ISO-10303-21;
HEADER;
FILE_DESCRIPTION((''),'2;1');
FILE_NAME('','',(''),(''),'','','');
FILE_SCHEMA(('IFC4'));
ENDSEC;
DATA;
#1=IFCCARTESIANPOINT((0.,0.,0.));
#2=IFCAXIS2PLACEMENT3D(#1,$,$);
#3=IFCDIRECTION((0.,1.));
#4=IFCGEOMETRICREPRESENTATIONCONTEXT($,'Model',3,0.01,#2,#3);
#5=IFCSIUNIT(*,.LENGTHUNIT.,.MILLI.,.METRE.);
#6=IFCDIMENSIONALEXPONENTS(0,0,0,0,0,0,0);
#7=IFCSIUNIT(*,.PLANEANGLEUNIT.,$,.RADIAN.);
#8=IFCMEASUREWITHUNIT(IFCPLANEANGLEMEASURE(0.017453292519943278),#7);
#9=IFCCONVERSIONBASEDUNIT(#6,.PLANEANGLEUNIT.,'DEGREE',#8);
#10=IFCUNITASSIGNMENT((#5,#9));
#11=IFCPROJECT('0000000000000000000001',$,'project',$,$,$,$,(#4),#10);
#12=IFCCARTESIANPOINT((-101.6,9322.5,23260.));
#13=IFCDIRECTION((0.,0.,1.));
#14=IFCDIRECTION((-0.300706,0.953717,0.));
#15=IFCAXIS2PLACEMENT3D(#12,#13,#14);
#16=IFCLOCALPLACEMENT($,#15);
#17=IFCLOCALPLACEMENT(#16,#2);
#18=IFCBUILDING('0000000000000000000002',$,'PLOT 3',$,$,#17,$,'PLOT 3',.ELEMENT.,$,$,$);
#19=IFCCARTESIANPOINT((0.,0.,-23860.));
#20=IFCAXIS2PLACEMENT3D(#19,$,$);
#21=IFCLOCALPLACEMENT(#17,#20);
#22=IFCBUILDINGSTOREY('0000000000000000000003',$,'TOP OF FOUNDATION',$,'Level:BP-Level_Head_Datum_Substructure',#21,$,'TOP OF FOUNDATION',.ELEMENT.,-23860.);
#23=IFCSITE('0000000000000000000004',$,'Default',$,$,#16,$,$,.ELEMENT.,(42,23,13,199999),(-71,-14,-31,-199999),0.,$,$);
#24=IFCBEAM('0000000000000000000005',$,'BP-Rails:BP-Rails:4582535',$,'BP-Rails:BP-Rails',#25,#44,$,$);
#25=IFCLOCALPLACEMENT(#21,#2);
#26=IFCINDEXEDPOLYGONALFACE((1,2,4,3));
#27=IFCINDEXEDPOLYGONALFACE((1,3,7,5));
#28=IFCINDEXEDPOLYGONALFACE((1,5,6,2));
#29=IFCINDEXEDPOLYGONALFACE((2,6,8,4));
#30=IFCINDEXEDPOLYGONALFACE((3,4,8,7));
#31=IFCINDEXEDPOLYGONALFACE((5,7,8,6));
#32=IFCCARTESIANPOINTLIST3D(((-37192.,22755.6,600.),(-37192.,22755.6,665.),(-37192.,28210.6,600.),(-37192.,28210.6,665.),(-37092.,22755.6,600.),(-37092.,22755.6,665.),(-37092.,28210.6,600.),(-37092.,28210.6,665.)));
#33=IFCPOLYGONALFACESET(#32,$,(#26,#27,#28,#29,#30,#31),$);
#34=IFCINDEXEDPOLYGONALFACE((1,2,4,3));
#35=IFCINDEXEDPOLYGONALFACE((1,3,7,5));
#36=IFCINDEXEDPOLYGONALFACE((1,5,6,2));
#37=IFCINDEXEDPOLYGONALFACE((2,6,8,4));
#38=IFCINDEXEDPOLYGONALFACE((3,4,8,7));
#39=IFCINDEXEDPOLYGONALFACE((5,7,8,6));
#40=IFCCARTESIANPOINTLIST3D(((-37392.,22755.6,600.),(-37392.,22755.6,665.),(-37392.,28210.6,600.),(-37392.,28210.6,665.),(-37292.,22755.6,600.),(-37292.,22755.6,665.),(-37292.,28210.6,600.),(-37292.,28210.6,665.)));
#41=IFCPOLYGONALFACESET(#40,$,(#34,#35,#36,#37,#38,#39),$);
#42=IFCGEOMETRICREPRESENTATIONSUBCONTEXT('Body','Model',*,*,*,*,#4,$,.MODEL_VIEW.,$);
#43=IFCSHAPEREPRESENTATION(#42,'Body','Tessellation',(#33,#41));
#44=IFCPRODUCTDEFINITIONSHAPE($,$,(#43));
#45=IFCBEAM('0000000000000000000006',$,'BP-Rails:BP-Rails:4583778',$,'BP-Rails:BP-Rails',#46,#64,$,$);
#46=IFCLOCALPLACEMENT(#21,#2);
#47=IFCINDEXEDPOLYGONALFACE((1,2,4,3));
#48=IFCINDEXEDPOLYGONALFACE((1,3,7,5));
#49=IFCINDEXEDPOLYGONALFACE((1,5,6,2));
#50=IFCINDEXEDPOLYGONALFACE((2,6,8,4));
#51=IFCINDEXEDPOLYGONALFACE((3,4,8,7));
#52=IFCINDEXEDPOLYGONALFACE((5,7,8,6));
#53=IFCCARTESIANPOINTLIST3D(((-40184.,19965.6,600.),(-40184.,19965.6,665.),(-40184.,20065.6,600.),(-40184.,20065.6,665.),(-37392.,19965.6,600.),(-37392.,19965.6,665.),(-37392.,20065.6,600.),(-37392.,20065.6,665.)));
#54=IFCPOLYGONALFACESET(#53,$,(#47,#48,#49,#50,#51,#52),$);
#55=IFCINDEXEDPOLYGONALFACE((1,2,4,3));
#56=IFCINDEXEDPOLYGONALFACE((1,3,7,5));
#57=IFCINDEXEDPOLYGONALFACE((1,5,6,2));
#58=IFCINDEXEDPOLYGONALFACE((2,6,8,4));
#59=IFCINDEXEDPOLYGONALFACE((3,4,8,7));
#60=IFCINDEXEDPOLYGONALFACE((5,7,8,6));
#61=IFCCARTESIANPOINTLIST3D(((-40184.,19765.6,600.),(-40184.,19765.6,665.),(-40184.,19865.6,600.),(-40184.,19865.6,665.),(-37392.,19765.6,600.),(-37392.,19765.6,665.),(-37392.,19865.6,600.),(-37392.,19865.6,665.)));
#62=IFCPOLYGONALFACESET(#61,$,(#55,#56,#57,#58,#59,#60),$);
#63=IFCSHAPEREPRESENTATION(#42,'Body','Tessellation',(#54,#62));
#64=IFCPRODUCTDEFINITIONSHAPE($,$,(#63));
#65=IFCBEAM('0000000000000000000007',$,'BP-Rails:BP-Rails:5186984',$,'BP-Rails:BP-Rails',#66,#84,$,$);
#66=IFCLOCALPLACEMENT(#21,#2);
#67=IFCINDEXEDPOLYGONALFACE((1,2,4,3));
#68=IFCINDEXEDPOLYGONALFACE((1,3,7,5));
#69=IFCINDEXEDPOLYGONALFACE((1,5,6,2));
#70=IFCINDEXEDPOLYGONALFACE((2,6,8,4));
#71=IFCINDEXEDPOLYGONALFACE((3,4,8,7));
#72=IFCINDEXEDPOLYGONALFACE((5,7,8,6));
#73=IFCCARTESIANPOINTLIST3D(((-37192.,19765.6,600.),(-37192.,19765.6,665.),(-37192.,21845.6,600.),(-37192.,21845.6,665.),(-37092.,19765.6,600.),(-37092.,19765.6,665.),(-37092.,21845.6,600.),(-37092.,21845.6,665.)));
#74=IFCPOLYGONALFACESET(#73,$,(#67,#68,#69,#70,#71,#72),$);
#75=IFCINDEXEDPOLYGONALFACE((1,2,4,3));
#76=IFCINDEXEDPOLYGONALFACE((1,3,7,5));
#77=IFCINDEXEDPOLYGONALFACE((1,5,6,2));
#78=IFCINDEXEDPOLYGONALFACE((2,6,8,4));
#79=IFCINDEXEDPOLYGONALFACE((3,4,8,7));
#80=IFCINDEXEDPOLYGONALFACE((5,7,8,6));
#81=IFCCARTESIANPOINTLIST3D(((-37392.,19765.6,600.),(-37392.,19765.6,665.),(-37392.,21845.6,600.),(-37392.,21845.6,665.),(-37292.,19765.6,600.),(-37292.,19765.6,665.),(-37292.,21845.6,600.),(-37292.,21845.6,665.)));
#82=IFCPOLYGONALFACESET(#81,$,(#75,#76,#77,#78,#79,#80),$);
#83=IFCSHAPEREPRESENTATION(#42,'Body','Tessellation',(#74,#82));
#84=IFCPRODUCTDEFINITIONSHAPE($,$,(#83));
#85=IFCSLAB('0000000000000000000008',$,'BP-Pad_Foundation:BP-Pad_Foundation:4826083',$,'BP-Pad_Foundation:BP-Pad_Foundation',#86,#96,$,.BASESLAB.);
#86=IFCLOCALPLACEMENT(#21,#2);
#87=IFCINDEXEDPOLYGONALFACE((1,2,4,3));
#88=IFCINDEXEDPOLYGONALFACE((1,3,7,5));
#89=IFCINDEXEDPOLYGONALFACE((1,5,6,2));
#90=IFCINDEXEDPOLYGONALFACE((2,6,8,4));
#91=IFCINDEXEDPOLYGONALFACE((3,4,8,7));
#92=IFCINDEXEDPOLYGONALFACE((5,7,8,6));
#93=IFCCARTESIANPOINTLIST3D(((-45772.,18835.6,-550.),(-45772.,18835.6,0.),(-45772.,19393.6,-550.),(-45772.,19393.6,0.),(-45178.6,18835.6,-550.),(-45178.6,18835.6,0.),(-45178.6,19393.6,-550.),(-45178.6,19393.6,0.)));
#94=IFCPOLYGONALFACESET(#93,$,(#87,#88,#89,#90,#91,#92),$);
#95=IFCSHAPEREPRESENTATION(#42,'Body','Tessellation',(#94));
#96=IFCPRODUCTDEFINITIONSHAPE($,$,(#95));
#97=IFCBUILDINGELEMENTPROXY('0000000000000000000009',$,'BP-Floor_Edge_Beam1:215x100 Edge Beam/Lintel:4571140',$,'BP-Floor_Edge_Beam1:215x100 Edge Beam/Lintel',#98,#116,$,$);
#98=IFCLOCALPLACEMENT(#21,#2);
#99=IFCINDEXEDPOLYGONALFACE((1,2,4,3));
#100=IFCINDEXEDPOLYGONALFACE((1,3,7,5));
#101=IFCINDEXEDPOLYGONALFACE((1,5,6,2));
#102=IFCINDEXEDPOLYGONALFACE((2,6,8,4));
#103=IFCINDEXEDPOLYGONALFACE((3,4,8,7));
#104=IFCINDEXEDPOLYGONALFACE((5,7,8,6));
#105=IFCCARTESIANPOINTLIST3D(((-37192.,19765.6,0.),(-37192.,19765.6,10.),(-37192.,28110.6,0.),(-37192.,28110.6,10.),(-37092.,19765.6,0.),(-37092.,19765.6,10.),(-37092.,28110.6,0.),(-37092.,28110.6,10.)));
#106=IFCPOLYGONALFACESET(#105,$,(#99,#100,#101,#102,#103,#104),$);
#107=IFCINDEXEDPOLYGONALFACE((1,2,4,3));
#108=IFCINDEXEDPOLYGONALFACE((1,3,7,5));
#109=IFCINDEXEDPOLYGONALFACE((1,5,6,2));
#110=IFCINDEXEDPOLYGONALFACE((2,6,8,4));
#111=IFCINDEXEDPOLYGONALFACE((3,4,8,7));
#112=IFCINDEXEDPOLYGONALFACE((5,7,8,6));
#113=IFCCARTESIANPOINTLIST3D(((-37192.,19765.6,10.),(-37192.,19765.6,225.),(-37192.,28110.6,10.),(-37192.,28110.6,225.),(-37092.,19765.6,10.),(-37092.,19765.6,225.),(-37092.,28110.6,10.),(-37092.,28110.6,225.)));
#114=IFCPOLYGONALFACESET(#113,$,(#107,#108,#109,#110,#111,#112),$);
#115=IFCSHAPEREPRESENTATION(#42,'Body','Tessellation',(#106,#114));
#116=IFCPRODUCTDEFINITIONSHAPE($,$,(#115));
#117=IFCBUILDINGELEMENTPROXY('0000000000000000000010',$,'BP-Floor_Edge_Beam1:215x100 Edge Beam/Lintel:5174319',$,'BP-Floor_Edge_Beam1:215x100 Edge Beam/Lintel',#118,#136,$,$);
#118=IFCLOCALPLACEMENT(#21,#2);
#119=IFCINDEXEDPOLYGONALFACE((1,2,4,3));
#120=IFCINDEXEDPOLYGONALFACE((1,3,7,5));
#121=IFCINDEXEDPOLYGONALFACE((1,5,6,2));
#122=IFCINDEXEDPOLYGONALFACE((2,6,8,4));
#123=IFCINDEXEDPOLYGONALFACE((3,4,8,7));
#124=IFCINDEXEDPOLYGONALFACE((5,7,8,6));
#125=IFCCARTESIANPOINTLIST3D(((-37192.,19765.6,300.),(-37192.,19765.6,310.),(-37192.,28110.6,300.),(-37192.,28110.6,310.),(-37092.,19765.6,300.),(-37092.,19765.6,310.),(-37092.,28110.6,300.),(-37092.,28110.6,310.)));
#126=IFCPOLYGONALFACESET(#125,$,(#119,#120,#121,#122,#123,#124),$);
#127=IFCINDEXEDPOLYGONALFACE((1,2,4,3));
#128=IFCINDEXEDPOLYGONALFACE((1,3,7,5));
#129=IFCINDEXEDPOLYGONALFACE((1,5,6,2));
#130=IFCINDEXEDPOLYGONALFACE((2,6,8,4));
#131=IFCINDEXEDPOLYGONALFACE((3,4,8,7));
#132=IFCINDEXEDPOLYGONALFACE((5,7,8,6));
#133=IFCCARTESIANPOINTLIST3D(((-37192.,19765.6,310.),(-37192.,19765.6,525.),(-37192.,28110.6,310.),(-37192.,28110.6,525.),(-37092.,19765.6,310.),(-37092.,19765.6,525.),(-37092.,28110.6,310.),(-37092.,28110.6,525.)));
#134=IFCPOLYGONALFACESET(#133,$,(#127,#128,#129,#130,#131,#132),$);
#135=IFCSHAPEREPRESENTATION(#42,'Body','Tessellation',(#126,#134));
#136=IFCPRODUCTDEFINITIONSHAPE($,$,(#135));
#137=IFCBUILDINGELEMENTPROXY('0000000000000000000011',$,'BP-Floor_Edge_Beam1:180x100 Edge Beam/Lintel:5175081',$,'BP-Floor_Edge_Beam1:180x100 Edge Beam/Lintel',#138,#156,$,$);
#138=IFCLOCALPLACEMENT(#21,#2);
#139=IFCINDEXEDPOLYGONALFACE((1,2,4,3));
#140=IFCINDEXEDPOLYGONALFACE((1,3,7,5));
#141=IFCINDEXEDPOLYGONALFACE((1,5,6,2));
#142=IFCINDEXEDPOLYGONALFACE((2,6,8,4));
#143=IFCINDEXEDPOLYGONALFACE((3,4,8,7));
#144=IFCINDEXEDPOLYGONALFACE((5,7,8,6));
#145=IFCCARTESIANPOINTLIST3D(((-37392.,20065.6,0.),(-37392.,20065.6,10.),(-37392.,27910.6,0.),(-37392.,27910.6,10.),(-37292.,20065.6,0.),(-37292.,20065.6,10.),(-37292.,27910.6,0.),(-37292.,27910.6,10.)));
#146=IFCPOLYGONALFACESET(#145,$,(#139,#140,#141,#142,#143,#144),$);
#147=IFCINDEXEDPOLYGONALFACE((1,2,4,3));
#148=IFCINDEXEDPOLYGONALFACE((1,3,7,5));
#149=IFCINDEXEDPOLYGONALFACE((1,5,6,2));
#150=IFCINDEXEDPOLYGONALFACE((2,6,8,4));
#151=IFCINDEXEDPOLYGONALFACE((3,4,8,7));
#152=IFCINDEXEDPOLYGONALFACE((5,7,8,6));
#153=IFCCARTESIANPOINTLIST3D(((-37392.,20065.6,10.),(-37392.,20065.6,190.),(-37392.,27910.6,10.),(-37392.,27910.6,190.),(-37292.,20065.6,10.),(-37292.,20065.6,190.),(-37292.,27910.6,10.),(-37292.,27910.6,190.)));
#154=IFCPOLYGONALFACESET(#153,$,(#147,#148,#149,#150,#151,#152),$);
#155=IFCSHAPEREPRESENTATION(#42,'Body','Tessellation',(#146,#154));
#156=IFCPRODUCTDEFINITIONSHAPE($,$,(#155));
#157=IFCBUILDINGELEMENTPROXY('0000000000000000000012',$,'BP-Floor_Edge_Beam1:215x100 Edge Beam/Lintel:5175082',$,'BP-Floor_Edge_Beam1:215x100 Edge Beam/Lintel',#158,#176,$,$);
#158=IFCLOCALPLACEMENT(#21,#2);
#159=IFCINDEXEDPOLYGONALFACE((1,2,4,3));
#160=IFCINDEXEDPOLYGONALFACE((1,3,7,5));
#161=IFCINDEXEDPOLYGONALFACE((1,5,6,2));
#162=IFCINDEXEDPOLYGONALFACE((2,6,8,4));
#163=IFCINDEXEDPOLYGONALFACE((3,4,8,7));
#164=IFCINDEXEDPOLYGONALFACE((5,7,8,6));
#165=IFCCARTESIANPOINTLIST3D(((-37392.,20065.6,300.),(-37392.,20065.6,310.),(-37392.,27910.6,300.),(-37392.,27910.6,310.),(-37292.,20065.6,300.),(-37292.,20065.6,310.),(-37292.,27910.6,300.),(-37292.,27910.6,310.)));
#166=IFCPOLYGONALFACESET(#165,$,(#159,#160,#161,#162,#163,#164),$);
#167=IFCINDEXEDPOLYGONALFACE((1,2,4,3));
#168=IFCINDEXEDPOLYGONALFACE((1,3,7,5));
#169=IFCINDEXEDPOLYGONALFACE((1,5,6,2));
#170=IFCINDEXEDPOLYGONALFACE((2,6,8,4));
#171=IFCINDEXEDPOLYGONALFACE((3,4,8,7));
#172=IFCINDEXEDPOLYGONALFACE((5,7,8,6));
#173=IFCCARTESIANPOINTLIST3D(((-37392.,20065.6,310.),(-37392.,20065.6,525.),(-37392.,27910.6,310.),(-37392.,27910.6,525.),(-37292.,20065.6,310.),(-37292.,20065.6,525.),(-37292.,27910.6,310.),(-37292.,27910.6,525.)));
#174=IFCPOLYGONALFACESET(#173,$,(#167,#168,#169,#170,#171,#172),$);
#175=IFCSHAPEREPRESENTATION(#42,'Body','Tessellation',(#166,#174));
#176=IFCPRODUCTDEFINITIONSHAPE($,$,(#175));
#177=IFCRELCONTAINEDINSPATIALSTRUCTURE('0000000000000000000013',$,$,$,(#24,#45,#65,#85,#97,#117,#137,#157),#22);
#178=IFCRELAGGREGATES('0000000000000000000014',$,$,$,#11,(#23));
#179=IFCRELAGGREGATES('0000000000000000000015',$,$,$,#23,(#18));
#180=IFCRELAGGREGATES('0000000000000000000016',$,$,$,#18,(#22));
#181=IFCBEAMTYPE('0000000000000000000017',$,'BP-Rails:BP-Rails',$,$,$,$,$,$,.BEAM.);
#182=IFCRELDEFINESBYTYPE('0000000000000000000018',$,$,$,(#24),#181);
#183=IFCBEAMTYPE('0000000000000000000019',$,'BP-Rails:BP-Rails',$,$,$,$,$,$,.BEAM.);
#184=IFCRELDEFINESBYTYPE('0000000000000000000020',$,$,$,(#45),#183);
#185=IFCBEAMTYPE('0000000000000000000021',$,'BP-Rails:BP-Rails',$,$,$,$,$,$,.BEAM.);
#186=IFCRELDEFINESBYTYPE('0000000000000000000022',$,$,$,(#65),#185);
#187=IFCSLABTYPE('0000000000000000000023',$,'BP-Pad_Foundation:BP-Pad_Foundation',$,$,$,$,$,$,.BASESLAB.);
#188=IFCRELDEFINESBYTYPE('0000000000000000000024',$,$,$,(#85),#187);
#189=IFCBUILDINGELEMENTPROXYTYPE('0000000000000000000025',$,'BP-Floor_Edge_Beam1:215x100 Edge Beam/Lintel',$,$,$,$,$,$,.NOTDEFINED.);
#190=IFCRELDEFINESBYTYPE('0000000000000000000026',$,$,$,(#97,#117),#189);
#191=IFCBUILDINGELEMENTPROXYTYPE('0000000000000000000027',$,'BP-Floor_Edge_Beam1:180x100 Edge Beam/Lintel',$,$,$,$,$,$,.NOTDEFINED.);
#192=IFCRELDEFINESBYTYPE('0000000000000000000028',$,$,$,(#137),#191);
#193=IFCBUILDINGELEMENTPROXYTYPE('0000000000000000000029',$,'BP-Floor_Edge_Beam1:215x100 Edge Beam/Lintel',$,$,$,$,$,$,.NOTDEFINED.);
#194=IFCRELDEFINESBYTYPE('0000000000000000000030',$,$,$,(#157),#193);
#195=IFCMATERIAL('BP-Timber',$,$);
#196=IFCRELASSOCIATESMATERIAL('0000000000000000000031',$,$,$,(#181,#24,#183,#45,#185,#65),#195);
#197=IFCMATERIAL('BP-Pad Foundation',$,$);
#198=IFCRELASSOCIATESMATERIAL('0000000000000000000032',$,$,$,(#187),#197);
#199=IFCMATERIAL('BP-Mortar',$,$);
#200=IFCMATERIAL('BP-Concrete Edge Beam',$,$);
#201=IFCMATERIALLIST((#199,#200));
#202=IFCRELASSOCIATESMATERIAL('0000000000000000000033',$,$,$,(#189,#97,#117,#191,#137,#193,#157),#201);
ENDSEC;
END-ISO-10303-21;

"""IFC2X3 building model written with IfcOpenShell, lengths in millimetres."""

from ifc_helpers import new_model, entity, si_unit, converted_unit, direction, frame, frame_2d, origin, origin_2d_with_axis, place, context, subcontext, project, spatial, rectangle, extrude, source, transform, mapped, material, material_list, type_object, type_shapes, element, save


model = new_model("IFC2X3")

# Units and contexts
model_context = context("Model", 3, precision=0.01, world=origin(), true_north=direction((0.0, 1.0)))
body_context = subcontext(model_context, "Body", "Model", "MODEL_VIEW")
ifc_project = project(units=[si_unit("LENGTHUNIT", "METRE", prefix="MILLI"), converted_unit("PLANEANGLEUNIT", "DEGREE", entity("IfcPlaneAngleMeasure", 0.017453292519943278), si_unit("PLANEANGLEUNIT", "RADIAN"), dimensions=[0, 0, 0, 0, 0, 0, 0])], contexts=[model_context])

# Site, building, storey
site_placement = place(None, frame((-101.6, 9322.5, 23260.0), z_axis=(0.0, 0.0, 1.0), x_axis=(-0.300706, 0.953717, 0.0)))
site = spatial("IfcSite", under=ifc_project, at=site_placement, Name="Default", CompositionType="ELEMENT", RefLatitude=(42, 23, 13, 199999), RefLongitude=(-71, -14, -31, -199999), RefElevation=0.0)
building_placement = place(site_placement, origin())
building = spatial("IfcBuilding", under=site, at=building_placement, Name="PLOT 3", LongName="PLOT 3", CompositionType="ELEMENT")
storey_placement = place(building_placement, frame((0.0, 0.0, -23860.0)))
storey = spatial("IfcBuildingStorey", under=building, at=storey_placement, Name="TOP OF FOUNDATION", ObjectType="Level:BP-Level_Head_Datum_Substructure", LongName="TOP OF FOUNDATION", CompositionType="ELEMENT", Elevation=-23860.0)

# Beams
ifc_material_1 = material(Name="BP-Timber")
beam_type_1 = type_object("IfcBeamType", Name="BP-Rails:BP-Rails", PredefinedType="BEAM", material=ifc_material_1)
shared_shape_1 = source(origin(), body_context, "Body", "SweptSolid", [
    extrude(rectangle(XDim=65.0, YDim=100.0, at=frame_2d((0.0, 0.0), x_axis=(1.0, 0.0))), frame((-2727.5, 100.0, -32.5), z_axis=(1.0, 0.0, 0.0), x_axis=(0.0, 0.0, -1.0)), (0.0, 0.0, 1.0), 5455.0),
    extrude(rectangle(XDim=65.0, YDim=100.0, at=origin_2d_with_axis()), frame((-2727.5, -100.0, -32.5), z_axis=(1.0, 0.0, 0.0), x_axis=(0.0, 0.0, -1.0)), (0.0, 0.0, 1.0), 5455.0),
])
type_shapes(beam_type_1, [shared_shape_1])
beam_1_placement = place(storey_placement, frame((-37242.0, 25483.1, 665.0), z_axis=(0.0, 0.0, 1.0), x_axis=(0.0, -1.0, 0.0)))
element("IfcBeam", 1, at=beam_1_placement, inside=storey, type_object=beam_type_1, material=ifc_material_1, Name="BP-Rails:BP-Rails:4582535", ObjectType="BP-Rails:BP-Rails", context=body_context, shape_type="MappedRepresentation", body=[
    mapped(shared_shape_1, transform((0.0, 0.0, 0.0), scale=1.0)),
])
beam_type_2 = type_object("IfcBeamType", Name="BP-Rails:BP-Rails", PredefinedType="BEAM", material=ifc_material_1)
shared_shape_2 = source(origin(), body_context, "Body", "SweptSolid", [
    extrude(rectangle(XDim=65.0, YDim=100.0, at=frame_2d((0.0, 0.0), x_axis=(1.0, 0.0))), frame((-1396.0, 100.0, -32.5), z_axis=(1.0, 0.0, 0.0), x_axis=(0.0, 0.0, -1.0)), (0.0, 0.0, 1.0), 2792.0),
    extrude(rectangle(XDim=65.0, YDim=100.0, at=origin_2d_with_axis()), frame((-1396.0, -100.0, -32.5), z_axis=(1.0, 0.0, 0.0), x_axis=(0.0, 0.0, -1.0)), (0.0, 0.0, 1.0), 2792.0),
])
type_shapes(beam_type_2, [shared_shape_2])
beam_2_placement = place(storey_placement, frame((-38788.0, 19915.6, 665.0)))
element("IfcBeam", 2, at=beam_2_placement, inside=storey, type_object=beam_type_2, material=ifc_material_1, Name="BP-Rails:BP-Rails:4583778", ObjectType="BP-Rails:BP-Rails", context=body_context, shape_type="MappedRepresentation", body=[
    mapped(shared_shape_2, transform((0.0, 0.0, 0.0), scale=1.0)),
])
beam_type_3 = type_object("IfcBeamType", Name="BP-Rails:BP-Rails", PredefinedType="BEAM", material=ifc_material_1)
shared_shape_3 = source(origin(), body_context, "Body", "SweptSolid", [
    extrude(rectangle(XDim=65.0, YDim=100.0, at=frame_2d((0.0, 0.0), x_axis=(1.0, 0.0))), frame((-1040.0, 100.0, -32.5), z_axis=(1.0, 0.0, 0.0), x_axis=(0.0, 0.0, -1.0)), (0.0, 0.0, 1.0), 2080.0),
    extrude(rectangle(XDim=65.0, YDim=100.0, at=origin_2d_with_axis()), frame((-1040.0, -100.0, -32.5), z_axis=(1.0, 0.0, 0.0), x_axis=(0.0, 0.0, -1.0)), (0.0, 0.0, 1.0), 2080.0),
])
type_shapes(beam_type_3, [shared_shape_3])
beam_3_placement = place(storey_placement, frame((-37242.0, 20805.6, 665.0), z_axis=(0.0, 0.0, 1.0), x_axis=(0.0, -1.0, 0.0)))
element("IfcBeam", 3, at=beam_3_placement, inside=storey, type_object=beam_type_3, material=ifc_material_1, Name="BP-Rails:BP-Rails:5186984", ObjectType="BP-Rails:BP-Rails", context=body_context, shape_type="MappedRepresentation", body=[
    mapped(shared_shape_3, transform((0.0, 0.0, 0.0), scale=1.0)),
])

# Slab
ifc_material_2 = material(Name="BP-Pad Foundation")
slab_type_1 = type_object("IfcSlabType", Name="BP-Pad_Foundation:BP-Pad_Foundation", PredefinedType="BASESLAB", material=ifc_material_2)
slab_1_placement = place(storey_placement, origin())
element("IfcSlab", 4, at=slab_1_placement, inside=storey, type_object=slab_type_1, Name="BP-Pad_Foundation:BP-Pad_Foundation:4826083", ObjectType="BP-Pad_Foundation:BP-Pad_Foundation", PredefinedType="BASESLAB", context=body_context, shape_type="SweptSolid", body=[
    extrude(rectangle(XDim=558.0, YDim=593.4, at=frame_2d((0.0, 0.0), x_axis=(1.0, 0.0))), frame((-45475.3, 19114.6, -550.0), z_axis=(0.0, 0.0, 1.0), x_axis=(0.0, 1.0, 0.0)), (0.0, 0.0, 1.0), 550.0),
])

# Building element proxies
ifc_material_3 = material(Name="BP-Mortar")
ifc_material_4 = material(Name="BP-Concrete Edge Beam")
ifc_material_list = material_list([ifc_material_3, ifc_material_4])
building_element_proxy_type_1 = type_object("IfcBuildingElementProxyType", Name="BP-Floor_Edge_Beam1:215x100 Edge Beam/Lintel", PredefinedType="NOTDEFINED", material=ifc_material_list)
shared_shape_4 = source(origin(), body_context, "Body", "SweptSolid", [
    extrude(rectangle(XDim=100.0, YDim=8345.0, at=frame_2d((0.0, 0.0), x_axis=(1.0, 0.0))), frame((0.0, 0.0, 0.0), z_axis=(0.0, 0.0, 1.0), x_axis=(0.0, 1.0, 0.0)), (0.0, 0.0, 1.0), 10.0),
    extrude(rectangle(XDim=100.0, YDim=8345.0, at=origin_2d_with_axis()), frame((0.0, 0.0, 10.0), z_axis=(0.0, 0.0, 1.0), x_axis=(0.0, 1.0, 0.0)), (0.0, 0.0, 1.0), 215.0),
])
type_shapes(building_element_proxy_type_1, [shared_shape_4])
for number, where, z_axis, x_axis, name in (
    (5, (-37142.0, 23938.1, 0.0), (0.0, 0.0, 1.0), (0.0, 1.0, 0.0), "BP-Floor_Edge_Beam1:215x100 Edge Beam/Lintel:4571140"),
    (6, (-37142.0, 23938.1, 300.0), (0.0, 0.0, 1.0), (0.0, 1.0, 0.0), "BP-Floor_Edge_Beam1:215x100 Edge Beam/Lintel:5174319"),
):
    element("IfcBuildingElementProxy", number, at=place(storey_placement, frame(where, z_axis=z_axis, x_axis=x_axis)), inside=storey, type_object=building_element_proxy_type_1, material=ifc_material_list, Name=name, ObjectType="BP-Floor_Edge_Beam1:215x100 Edge Beam/Lintel", context=body_context, shape_type="MappedRepresentation", body=[
        mapped(shared_shape_4, transform((0.0, 0.0, 0.0), scale=1.0)),
    ])
building_element_proxy_type_2 = type_object("IfcBuildingElementProxyType", Name="BP-Floor_Edge_Beam1:180x100 Edge Beam/Lintel", PredefinedType="NOTDEFINED", material=ifc_material_list)
shared_shape_5 = source(origin(), body_context, "Body", "SweptSolid", [
    extrude(rectangle(XDim=100.0, YDim=7845.0, at=frame_2d((0.0, 0.0), x_axis=(1.0, 0.0))), frame((0.0, 0.0, 0.0), z_axis=(0.0, 0.0, 1.0), x_axis=(0.0, 1.0, 0.0)), (0.0, 0.0, 1.0), 10.0),
    extrude(rectangle(XDim=100.0, YDim=7845.0, at=origin_2d_with_axis()), frame((0.0, 0.0, 10.0), z_axis=(0.0, 0.0, 1.0), x_axis=(0.0, 1.0, 0.0)), (0.0, 0.0, 1.0), 180.0),
])
type_shapes(building_element_proxy_type_2, [shared_shape_5])
proxy_1_placement = place(storey_placement, frame((-37342.0, 23988.1, 0.0), z_axis=(0.0, 0.0, 1.0), x_axis=(0.0, 1.0, 0.0)))
element("IfcBuildingElementProxy", 7, at=proxy_1_placement, inside=storey, type_object=building_element_proxy_type_2, material=ifc_material_list, Name="BP-Floor_Edge_Beam1:180x100 Edge Beam/Lintel:5175081", ObjectType="BP-Floor_Edge_Beam1:180x100 Edge Beam/Lintel", context=body_context, shape_type="MappedRepresentation", body=[
    mapped(shared_shape_5, transform((0.0, 0.0, 0.0), scale=1.0)),
])
building_element_proxy_type_3 = type_object("IfcBuildingElementProxyType", Name="BP-Floor_Edge_Beam1:215x100 Edge Beam/Lintel", PredefinedType="NOTDEFINED", material=ifc_material_list)
shared_shape_6 = source(origin(), body_context, "Body", "SweptSolid", [
    extrude(rectangle(XDim=100.0, YDim=7845.0, at=frame_2d((0.0, 0.0), x_axis=(1.0, 0.0))), frame((0.0, 0.0, 0.0), z_axis=(0.0, 0.0, 1.0), x_axis=(0.0, 1.0, 0.0)), (0.0, 0.0, 1.0), 10.0),
    extrude(rectangle(XDim=100.0, YDim=7845.0, at=origin_2d_with_axis()), frame((0.0, 0.0, 10.0), z_axis=(0.0, 0.0, 1.0), x_axis=(0.0, 1.0, 0.0)), (0.0, 0.0, 1.0), 215.0),
])
type_shapes(building_element_proxy_type_3, [shared_shape_6])
proxy_2_placement = place(storey_placement, frame((-37342.0, 23988.1, 300.0), z_axis=(0.0, 0.0, 1.0), x_axis=(0.0, 1.0, 0.0)))
element("IfcBuildingElementProxy", 8, at=proxy_2_placement, inside=storey, type_object=building_element_proxy_type_3, material=ifc_material_list, Name="BP-Floor_Edge_Beam1:215x100 Edge Beam/Lintel:5175082", ObjectType="BP-Floor_Edge_Beam1:215x100 Edge Beam/Lintel", context=body_context, shape_type="MappedRepresentation", body=[
    mapped(shared_shape_6, transform((0.0, 0.0, 0.0), scale=1.0)),
])

save(model, "model.ifc")
